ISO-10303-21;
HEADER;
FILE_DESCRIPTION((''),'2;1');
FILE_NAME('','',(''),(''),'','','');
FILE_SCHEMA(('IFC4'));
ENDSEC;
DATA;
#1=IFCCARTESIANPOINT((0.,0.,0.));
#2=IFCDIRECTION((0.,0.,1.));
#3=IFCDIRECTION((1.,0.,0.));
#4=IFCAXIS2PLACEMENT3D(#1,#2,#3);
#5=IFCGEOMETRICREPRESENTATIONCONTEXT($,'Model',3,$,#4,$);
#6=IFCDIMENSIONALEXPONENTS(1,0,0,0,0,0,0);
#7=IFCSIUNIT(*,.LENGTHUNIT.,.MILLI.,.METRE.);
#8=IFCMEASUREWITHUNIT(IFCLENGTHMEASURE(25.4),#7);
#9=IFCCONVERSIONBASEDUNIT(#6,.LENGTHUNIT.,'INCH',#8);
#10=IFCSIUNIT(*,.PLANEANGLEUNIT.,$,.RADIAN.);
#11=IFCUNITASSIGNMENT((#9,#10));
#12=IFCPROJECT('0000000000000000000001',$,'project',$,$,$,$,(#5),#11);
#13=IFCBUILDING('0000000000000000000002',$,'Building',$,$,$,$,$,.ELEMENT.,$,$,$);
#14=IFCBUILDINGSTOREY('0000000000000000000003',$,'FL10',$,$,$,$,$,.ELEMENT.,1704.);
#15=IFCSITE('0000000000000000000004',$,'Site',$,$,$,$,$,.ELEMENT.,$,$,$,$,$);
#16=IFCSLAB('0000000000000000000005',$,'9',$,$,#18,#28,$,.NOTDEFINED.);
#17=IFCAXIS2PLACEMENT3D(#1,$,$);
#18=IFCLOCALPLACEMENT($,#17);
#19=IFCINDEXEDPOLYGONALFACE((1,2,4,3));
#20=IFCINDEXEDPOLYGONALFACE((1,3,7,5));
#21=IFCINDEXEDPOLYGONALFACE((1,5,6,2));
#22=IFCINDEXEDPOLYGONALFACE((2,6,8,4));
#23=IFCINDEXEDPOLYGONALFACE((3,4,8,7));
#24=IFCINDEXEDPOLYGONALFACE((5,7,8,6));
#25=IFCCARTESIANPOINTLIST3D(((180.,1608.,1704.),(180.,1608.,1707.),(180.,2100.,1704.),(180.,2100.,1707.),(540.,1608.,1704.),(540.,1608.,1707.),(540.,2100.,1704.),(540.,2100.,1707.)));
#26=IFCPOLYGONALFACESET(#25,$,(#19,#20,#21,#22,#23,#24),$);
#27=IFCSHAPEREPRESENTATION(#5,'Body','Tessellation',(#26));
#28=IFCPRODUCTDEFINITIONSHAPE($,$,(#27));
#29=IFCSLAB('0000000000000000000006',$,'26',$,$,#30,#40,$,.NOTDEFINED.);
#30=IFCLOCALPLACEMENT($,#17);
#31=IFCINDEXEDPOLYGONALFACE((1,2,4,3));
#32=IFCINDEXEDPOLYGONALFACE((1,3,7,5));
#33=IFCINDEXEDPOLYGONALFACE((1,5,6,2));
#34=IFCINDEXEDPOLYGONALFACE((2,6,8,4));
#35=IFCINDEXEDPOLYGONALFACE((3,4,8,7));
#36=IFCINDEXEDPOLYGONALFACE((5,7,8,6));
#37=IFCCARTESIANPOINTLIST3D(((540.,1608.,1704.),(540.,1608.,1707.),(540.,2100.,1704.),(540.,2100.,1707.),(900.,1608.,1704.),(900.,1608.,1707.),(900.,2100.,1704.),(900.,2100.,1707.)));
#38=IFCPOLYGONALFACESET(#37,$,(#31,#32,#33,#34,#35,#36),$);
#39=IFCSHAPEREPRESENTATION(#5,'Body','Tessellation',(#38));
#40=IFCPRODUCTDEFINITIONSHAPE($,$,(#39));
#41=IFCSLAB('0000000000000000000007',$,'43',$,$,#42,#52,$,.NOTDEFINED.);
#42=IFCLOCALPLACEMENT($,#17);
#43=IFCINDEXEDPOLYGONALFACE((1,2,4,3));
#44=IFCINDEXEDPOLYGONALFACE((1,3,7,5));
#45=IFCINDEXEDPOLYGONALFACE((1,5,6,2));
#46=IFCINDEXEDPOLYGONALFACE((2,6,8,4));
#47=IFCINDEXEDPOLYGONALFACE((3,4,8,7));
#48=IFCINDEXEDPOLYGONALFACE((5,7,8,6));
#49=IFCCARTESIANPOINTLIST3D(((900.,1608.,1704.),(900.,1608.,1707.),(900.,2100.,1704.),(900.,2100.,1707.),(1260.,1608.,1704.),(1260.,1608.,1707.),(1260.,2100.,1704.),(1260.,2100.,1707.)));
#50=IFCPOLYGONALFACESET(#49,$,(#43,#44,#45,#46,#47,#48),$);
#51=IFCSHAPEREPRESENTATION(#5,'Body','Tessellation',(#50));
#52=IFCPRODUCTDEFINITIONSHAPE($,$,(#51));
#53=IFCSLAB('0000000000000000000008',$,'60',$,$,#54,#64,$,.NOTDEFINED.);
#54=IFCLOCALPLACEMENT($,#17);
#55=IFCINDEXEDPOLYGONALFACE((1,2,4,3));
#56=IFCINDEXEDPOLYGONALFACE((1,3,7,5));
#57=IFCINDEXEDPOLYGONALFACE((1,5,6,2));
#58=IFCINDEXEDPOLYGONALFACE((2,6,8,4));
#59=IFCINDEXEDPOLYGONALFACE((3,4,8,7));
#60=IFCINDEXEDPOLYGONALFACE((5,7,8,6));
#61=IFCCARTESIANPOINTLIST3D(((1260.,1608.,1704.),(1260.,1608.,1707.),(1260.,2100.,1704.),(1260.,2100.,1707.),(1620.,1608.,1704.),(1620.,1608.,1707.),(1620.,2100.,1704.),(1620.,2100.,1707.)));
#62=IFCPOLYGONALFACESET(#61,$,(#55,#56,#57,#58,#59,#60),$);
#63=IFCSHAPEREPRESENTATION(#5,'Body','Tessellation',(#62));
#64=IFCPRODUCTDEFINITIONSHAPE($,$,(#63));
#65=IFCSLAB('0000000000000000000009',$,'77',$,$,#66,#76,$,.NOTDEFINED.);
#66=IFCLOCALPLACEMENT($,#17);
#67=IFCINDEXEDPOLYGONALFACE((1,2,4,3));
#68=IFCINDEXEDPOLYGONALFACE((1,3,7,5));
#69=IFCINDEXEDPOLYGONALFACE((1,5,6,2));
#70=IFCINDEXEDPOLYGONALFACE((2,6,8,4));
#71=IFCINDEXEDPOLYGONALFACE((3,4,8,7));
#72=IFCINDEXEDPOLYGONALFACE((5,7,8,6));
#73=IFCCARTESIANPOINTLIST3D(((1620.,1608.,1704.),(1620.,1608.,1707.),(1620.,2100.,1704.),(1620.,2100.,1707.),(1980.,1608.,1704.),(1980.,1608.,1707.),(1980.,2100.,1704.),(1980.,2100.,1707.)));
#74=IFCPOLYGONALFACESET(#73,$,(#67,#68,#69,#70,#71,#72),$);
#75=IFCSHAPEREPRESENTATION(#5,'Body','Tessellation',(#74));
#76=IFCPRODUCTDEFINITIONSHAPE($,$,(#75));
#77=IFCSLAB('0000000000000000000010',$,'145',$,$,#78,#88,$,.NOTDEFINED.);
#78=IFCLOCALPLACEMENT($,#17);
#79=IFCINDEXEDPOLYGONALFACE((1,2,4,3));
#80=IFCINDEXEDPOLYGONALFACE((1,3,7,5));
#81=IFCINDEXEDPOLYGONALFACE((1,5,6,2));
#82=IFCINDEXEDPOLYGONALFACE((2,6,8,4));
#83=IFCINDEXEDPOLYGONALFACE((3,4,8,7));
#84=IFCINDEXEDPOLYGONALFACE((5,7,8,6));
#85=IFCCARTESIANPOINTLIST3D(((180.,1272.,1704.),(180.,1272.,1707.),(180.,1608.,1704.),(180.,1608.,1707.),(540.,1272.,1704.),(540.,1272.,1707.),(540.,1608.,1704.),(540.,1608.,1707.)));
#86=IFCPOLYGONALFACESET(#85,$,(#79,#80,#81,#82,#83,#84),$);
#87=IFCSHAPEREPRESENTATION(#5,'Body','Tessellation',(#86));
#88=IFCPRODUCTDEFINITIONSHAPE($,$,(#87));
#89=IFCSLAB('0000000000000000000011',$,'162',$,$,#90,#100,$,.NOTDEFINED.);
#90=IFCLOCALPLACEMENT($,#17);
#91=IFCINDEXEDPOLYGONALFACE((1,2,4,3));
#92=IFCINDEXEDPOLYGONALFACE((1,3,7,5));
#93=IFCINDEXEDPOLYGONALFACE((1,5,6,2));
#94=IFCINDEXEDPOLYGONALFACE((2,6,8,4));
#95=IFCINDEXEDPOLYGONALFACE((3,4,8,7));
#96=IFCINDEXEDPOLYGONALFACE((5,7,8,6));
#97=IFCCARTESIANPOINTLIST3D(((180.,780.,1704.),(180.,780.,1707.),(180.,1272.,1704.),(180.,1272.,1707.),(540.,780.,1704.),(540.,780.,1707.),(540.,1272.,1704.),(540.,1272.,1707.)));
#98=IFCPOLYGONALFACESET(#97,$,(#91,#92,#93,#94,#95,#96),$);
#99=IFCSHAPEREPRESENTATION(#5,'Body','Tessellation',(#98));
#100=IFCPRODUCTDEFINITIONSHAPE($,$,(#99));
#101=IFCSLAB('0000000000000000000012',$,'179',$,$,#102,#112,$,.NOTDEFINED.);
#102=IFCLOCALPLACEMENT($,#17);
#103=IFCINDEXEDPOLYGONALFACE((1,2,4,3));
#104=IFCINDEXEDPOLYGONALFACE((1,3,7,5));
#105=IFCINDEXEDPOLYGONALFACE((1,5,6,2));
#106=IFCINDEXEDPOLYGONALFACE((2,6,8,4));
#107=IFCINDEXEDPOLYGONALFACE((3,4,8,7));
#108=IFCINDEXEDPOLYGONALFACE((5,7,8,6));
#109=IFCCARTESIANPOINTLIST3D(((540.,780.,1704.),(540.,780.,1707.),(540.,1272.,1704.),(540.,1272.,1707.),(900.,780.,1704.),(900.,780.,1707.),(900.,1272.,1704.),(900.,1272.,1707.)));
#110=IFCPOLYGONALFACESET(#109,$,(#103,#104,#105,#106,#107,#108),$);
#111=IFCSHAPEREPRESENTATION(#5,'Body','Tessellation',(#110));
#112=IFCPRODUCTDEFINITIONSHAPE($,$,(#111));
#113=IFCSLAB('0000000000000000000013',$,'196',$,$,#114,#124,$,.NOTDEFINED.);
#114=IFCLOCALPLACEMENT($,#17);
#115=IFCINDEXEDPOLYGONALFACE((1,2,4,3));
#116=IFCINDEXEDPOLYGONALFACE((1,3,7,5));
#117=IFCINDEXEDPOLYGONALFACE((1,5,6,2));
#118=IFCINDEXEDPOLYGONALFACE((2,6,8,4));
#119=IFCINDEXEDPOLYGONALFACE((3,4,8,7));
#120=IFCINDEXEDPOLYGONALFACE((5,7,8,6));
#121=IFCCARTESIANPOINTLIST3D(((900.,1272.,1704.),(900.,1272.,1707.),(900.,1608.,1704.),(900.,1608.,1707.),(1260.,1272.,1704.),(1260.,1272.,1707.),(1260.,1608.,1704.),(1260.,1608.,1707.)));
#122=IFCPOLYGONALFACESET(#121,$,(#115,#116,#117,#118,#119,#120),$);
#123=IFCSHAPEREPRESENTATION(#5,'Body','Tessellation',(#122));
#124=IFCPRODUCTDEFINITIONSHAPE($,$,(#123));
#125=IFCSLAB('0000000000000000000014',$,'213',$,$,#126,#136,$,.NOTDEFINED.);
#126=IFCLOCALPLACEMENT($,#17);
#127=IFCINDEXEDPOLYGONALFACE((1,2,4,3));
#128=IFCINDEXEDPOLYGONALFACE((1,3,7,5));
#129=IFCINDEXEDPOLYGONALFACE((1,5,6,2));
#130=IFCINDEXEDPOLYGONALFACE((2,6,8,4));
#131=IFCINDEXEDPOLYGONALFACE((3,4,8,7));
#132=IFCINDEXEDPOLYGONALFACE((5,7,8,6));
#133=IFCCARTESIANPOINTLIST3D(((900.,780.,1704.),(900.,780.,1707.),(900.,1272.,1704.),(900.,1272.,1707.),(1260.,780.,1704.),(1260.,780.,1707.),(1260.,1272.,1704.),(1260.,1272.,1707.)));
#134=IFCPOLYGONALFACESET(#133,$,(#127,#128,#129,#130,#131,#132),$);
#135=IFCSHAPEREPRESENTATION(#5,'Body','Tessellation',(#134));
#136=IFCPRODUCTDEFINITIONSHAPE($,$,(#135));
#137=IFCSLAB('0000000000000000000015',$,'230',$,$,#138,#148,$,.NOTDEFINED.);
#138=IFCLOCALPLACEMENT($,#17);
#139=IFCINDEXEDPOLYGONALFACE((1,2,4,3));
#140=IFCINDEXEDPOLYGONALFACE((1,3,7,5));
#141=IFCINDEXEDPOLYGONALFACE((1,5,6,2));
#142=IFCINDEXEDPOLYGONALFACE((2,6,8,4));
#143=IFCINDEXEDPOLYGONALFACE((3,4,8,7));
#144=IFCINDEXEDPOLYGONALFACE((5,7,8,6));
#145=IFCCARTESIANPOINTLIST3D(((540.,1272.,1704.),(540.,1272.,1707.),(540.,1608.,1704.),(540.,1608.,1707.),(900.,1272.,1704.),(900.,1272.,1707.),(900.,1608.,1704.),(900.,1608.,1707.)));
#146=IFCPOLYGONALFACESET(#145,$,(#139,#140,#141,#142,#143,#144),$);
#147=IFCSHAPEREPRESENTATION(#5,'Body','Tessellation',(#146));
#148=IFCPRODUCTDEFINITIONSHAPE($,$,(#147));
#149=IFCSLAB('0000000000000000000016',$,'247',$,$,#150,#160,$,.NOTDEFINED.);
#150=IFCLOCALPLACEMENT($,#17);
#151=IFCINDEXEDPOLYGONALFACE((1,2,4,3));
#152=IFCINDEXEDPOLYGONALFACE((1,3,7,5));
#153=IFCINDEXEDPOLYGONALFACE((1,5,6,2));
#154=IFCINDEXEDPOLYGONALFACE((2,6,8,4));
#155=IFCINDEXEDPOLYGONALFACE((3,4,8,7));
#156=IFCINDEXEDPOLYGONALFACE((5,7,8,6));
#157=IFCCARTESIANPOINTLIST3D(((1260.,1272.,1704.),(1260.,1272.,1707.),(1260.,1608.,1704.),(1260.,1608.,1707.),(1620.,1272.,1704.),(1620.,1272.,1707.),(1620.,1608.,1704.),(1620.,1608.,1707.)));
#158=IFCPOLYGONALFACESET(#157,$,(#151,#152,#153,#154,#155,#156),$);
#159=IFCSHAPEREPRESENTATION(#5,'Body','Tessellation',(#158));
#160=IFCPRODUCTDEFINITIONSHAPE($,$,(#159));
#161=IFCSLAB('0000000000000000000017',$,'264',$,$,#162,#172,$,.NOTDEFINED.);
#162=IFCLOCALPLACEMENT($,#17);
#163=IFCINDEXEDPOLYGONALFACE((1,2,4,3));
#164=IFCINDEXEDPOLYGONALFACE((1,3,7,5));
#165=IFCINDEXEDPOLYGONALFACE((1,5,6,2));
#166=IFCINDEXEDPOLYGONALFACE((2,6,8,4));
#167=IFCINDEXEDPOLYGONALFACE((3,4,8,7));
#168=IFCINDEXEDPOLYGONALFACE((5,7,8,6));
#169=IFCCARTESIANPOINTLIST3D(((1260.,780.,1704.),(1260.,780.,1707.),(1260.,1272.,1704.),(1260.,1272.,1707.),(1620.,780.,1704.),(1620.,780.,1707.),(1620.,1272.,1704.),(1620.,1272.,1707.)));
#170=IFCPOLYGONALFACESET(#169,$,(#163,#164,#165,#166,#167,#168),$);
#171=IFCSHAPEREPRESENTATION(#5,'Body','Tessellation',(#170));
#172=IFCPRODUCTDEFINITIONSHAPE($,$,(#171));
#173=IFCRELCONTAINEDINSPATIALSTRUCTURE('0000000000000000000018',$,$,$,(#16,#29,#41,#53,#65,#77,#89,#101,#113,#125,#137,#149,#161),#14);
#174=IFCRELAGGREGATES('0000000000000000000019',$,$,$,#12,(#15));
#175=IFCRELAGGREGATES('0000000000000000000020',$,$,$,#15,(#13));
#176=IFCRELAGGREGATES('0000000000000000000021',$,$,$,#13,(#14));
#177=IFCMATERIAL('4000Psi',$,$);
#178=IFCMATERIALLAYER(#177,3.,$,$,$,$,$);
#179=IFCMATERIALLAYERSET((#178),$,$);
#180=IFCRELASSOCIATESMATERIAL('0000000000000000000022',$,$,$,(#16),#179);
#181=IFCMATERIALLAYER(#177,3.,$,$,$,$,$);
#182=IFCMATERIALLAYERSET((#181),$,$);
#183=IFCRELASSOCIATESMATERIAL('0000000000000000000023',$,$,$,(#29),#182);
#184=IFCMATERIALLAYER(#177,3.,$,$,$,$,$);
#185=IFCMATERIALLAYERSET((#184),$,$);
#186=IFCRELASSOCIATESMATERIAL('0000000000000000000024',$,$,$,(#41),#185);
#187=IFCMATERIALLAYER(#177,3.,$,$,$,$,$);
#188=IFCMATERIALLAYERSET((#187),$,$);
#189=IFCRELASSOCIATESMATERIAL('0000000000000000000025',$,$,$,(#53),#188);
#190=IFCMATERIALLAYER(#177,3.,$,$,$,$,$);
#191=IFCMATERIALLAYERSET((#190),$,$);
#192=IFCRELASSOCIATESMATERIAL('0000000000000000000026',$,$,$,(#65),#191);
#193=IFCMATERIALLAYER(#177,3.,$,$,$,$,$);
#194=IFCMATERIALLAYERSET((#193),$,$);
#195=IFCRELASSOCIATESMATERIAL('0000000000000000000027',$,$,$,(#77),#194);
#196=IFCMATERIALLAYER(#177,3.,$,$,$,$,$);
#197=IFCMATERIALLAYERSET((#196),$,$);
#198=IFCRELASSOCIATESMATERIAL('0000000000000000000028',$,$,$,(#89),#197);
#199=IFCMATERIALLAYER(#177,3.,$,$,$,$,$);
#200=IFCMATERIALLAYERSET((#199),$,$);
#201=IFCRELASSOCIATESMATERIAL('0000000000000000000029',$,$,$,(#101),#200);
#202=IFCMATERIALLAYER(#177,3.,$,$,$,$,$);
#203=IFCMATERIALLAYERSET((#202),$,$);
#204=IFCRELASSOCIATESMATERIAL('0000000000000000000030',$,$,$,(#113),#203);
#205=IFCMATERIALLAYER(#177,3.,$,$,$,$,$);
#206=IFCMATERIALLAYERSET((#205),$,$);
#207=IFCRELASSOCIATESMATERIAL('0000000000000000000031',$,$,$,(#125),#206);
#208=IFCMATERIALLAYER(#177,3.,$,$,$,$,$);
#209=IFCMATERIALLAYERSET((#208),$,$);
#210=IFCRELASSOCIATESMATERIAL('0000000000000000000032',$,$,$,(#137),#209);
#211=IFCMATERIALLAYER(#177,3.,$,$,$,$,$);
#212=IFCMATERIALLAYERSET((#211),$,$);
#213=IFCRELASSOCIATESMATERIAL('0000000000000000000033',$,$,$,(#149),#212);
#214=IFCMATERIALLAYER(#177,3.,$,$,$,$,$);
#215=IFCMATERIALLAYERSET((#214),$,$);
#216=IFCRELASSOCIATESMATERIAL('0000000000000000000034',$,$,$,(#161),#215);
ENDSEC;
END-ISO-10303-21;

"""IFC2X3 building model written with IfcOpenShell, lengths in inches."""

from ifc_helpers import new_model, entity, si_unit, converted_unit, frame, origin_with_axes, place, context, project, spatial, polyline, outline, extrude, material, layer, layer_set, layer_usage, element, save


model = new_model("IFC2X3")

# Units and contexts
model_context = context("Model", 3, world=origin_with_axes())
ifc_project = project(units=[converted_unit("LENGTHUNIT", "INCH", entity("IfcLengthMeasure", 25.4), si_unit("LENGTHUNIT", "METRE", prefix="MILLI"), dimensions=[1, 0, 0, 0, 0, 0, 0]), si_unit("PLANEANGLEUNIT", "RADIAN")], contexts=[model_context])

# Site, building, storey
site = spatial("IfcSite", under=ifc_project, Name="Site", CompositionType="ELEMENT")
building = spatial("IfcBuilding", under=site, Name="Building", CompositionType="ELEMENT")
storey = spatial("IfcBuildingStorey", under=building, Name="FL10", CompositionType="ELEMENT", Elevation=1704.0)

# Slabs
ifc_material_1 = material(Name="4000Psi")
ifc_layer_1 = layer(ifc_material_1, 3.0)
ifc_layer_set_1 = layer_set([ifc_layer_1])
ifc_layer_usage_1 = layer_usage(ifc_layer_set_1, "AXIS2", "POSITIVE", -3.0)
slab_1_placement = place(None, frame((180.0, 1608.0, 1704.0), z_axis=(0.0, 0.0, 1.0), x_axis=(1.0, 0.0, 0.0)))
element("IfcSlab", 1, at=slab_1_placement, inside=storey, material=ifc_layer_usage_1, Name="9", PredefinedType="NOTDEFINED", context=model_context, shape_type="SweptSolid", body=[
    extrude(outline(polyline([(0.0, 0.0), (360.0, 0.0), (360.0, 492.0), (0.0, 492.0), (0.0, 0.0)])), origin_with_axes(), (0.0, 0.0, 1.0), 3.0),
])
ifc_layer_2 = layer(ifc_material_1, 3.0)
ifc_layer_set_2 = layer_set([ifc_layer_2])
ifc_layer_usage_2 = layer_usage(ifc_layer_set_2, "AXIS2", "POSITIVE", -3.0)
slab_2_placement = place(None, frame((540.0, 1608.0, 1704.0), z_axis=(0.0, 0.0, 1.0), x_axis=(1.0, 0.0, 0.0)))
element("IfcSlab", 2, at=slab_2_placement, inside=storey, material=ifc_layer_usage_2, Name="26", PredefinedType="NOTDEFINED", context=model_context, shape_type="SweptSolid", body=[
    extrude(outline(polyline([(0.0, 0.0), (360.0, 0.0), (360.0, 492.0), (0.0, 492.0), (0.0, 0.0)])), origin_with_axes(), (0.0, 0.0, 1.0), 3.0),
])
ifc_layer_3 = layer(ifc_material_1, 3.0)
ifc_layer_set_3 = layer_set([ifc_layer_3])
ifc_layer_usage_3 = layer_usage(ifc_layer_set_3, "AXIS2", "POSITIVE", -3.0)
slab_3_placement = place(None, frame((900.0, 1608.0, 1704.0), z_axis=(0.0, 0.0, 1.0), x_axis=(1.0, 0.0, 0.0)))
element("IfcSlab", 3, at=slab_3_placement, inside=storey, material=ifc_layer_usage_3, Name="43", PredefinedType="NOTDEFINED", context=model_context, shape_type="SweptSolid", body=[
    extrude(outline(polyline([(0.0, 0.0), (360.0, 0.0), (360.0, 492.0), (0.0, 492.0), (0.0, 0.0)])), origin_with_axes(), (0.0, 0.0, 1.0), 3.0),
])
ifc_layer_4 = layer(ifc_material_1, 3.0)
ifc_layer_set_4 = layer_set([ifc_layer_4])
ifc_layer_usage_4 = layer_usage(ifc_layer_set_4, "AXIS2", "POSITIVE", -3.0)
slab_4_placement = place(None, frame((1260.0, 1608.0, 1704.0), z_axis=(0.0, 0.0, 1.0), x_axis=(1.0, 0.0, 0.0)))
element("IfcSlab", 4, at=slab_4_placement, inside=storey, material=ifc_layer_usage_4, Name="60", PredefinedType="NOTDEFINED", context=model_context, shape_type="SweptSolid", body=[
    extrude(outline(polyline([(0.0, 0.0), (360.0, 0.0), (360.0, 492.0), (0.0, 492.0), (0.0, 0.0)])), origin_with_axes(), (0.0, 0.0, 1.0), 3.0),
])
ifc_layer_5 = layer(ifc_material_1, 3.0)
ifc_layer_set_5 = layer_set([ifc_layer_5])
ifc_layer_usage_5 = layer_usage(ifc_layer_set_5, "AXIS2", "POSITIVE", -3.0)
slab_5_placement = place(None, frame((1620.0, 1608.0, 1704.0), z_axis=(0.0, 0.0, 1.0), x_axis=(1.0, 0.0, 0.0)))
element("IfcSlab", 5, at=slab_5_placement, inside=storey, material=ifc_layer_usage_5, Name="77", PredefinedType="NOTDEFINED", context=model_context, shape_type="SweptSolid", body=[
    extrude(outline(polyline([(0.0, 0.0), (360.0, 0.0), (360.0, 492.0), (0.0, 492.0), (0.0, 0.0)])), origin_with_axes(), (0.0, 0.0, 1.0), 3.0),
])
ifc_layer_6 = layer(ifc_material_1, 3.0)
ifc_layer_set_6 = layer_set([ifc_layer_6])
ifc_layer_usage_6 = layer_usage(ifc_layer_set_6, "AXIS2", "POSITIVE", -3.0)
slab_6_placement = place(None, frame((180.0, 1272.0, 1704.0), z_axis=(0.0, 0.0, 1.0), x_axis=(1.0, 0.0, 0.0)))
element("IfcSlab", 6, at=slab_6_placement, inside=storey, material=ifc_layer_usage_6, Name="145", PredefinedType="NOTDEFINED", context=model_context, shape_type="SweptSolid", body=[
    extrude(outline(polyline([(0.0, 0.0), (360.0, 0.0), (360.0, 336.0), (0.0, 336.0), (0.0, 0.0)])), origin_with_axes(), (0.0, 0.0, 1.0), 3.0),
])
ifc_layer_7 = layer(ifc_material_1, 3.0)
ifc_layer_set_7 = layer_set([ifc_layer_7])
ifc_layer_usage_7 = layer_usage(ifc_layer_set_7, "AXIS2", "POSITIVE", -3.0)
slab_7_placement = place(None, frame((180.0, 780.0, 1704.0), z_axis=(0.0, 0.0, 1.0), x_axis=(1.0, 0.0, 0.0)))
element("IfcSlab", 7, at=slab_7_placement, inside=storey, material=ifc_layer_usage_7, Name="162", PredefinedType="NOTDEFINED", context=model_context, shape_type="SweptSolid", body=[
    extrude(outline(polyline([(0.0, 0.0), (360.0, 0.0), (360.0, 492.0), (0.0, 492.0), (0.0, 0.0)])), origin_with_axes(), (0.0, 0.0, 1.0), 3.0),
])
ifc_layer_8 = layer(ifc_material_1, 3.0)
ifc_layer_set_8 = layer_set([ifc_layer_8])
ifc_layer_usage_8 = layer_usage(ifc_layer_set_8, "AXIS2", "POSITIVE", -3.0)
slab_8_placement = place(None, frame((540.0, 780.0, 1704.0), z_axis=(0.0, 0.0, 1.0), x_axis=(1.0, 0.0, 0.0)))
element("IfcSlab", 8, at=slab_8_placement, inside=storey, material=ifc_layer_usage_8, Name="179", PredefinedType="NOTDEFINED", context=model_context, shape_type="SweptSolid", body=[
    extrude(outline(polyline([(0.0, 0.0), (360.0, 0.0), (360.0, 492.0), (0.0, 492.0), (0.0, 0.0)])), origin_with_axes(), (0.0, 0.0, 1.0), 3.0),
])
ifc_layer_9 = layer(ifc_material_1, 3.0)
ifc_layer_set_9 = layer_set([ifc_layer_9])
ifc_layer_usage_9 = layer_usage(ifc_layer_set_9, "AXIS2", "POSITIVE", -3.0)
slab_9_placement = place(None, frame((900.0, 1272.0, 1704.0), z_axis=(0.0, 0.0, 1.0), x_axis=(1.0, 0.0, 0.0)))
element("IfcSlab", 9, at=slab_9_placement, inside=storey, material=ifc_layer_usage_9, Name="196", PredefinedType="NOTDEFINED", context=model_context, shape_type="SweptSolid", body=[
    extrude(outline(polyline([(0.0, 0.0), (360.0, 0.0), (360.0, 336.0), (0.0, 336.0), (0.0, 0.0)])), origin_with_axes(), (0.0, 0.0, 1.0), 3.0),
])
ifc_layer_10 = layer(ifc_material_1, 3.0)
ifc_layer_set_10 = layer_set([ifc_layer_10])
ifc_layer_usage_10 = layer_usage(ifc_layer_set_10, "AXIS2", "POSITIVE", -3.0)
slab_10_placement = place(None, frame((900.0, 780.0, 1704.0), z_axis=(0.0, 0.0, 1.0), x_axis=(1.0, 0.0, 0.0)))
element("IfcSlab", 10, at=slab_10_placement, inside=storey, material=ifc_layer_usage_10, Name="213", PredefinedType="NOTDEFINED", context=model_context, shape_type="SweptSolid", body=[
    extrude(outline(polyline([(0.0, 0.0), (360.0, 0.0), (360.0, 492.0), (0.0, 492.0), (0.0, 0.0)])), origin_with_axes(), (0.0, 0.0, 1.0), 3.0),
])
ifc_layer_11 = layer(ifc_material_1, 3.0)
ifc_layer_set_11 = layer_set([ifc_layer_11])
ifc_layer_usage_11 = layer_usage(ifc_layer_set_11, "AXIS2", "POSITIVE", -3.0)
slab_11_placement = place(None, frame((540.0, 1272.0, 1704.0), z_axis=(0.0, 0.0, 1.0), x_axis=(1.0, 0.0, 0.0)))
element("IfcSlab", 11, at=slab_11_placement, inside=storey, material=ifc_layer_usage_11, Name="230", PredefinedType="NOTDEFINED", context=model_context, shape_type="SweptSolid", body=[
    extrude(outline(polyline([(0.0, 0.0), (360.0, 0.0), (360.0, 336.0), (0.0, 336.0), (0.0, 0.0)])), origin_with_axes(), (0.0, 0.0, 1.0), 3.0),
])
ifc_layer_12 = layer(ifc_material_1, 3.0)
ifc_layer_set_12 = layer_set([ifc_layer_12])
ifc_layer_usage_12 = layer_usage(ifc_layer_set_12, "AXIS2", "POSITIVE", -3.0)
slab_12_placement = place(None, frame((1260.0, 1272.0, 1704.0), z_axis=(0.0, 0.0, 1.0), x_axis=(1.0, 0.0, 0.0)))
element("IfcSlab", 12, at=slab_12_placement, inside=storey, material=ifc_layer_usage_12, Name="247", PredefinedType="NOTDEFINED", context=model_context, shape_type="SweptSolid", body=[
    extrude(outline(polyline([(0.0, 0.0), (360.0, 0.0), (360.0, 336.0), (0.0, 336.0), (0.0, 0.0)])), origin_with_axes(), (0.0, 0.0, 1.0), 3.0),
])
ifc_layer_13 = layer(ifc_material_1, 3.0)
ifc_layer_set_13 = layer_set([ifc_layer_13])
ifc_layer_usage_13 = layer_usage(ifc_layer_set_13, "AXIS2", "POSITIVE", -3.0)
slab_13_placement = place(None, frame((1260.0, 780.0, 1704.0), z_axis=(0.0, 0.0, 1.0), x_axis=(1.0, 0.0, 0.0)))
element("IfcSlab", 13, at=slab_13_placement, inside=storey, material=ifc_layer_usage_13, Name="264", PredefinedType="NOTDEFINED", context=model_context, shape_type="SweptSolid", body=[
    extrude(outline(polyline([(0.0, 0.0), (360.0, 0.0), (360.0, 492.0), (0.0, 492.0), (0.0, 0.0)])), origin_with_axes(), (0.0, 0.0, 1.0), 3.0),
])

save(model, "model.ifc")
